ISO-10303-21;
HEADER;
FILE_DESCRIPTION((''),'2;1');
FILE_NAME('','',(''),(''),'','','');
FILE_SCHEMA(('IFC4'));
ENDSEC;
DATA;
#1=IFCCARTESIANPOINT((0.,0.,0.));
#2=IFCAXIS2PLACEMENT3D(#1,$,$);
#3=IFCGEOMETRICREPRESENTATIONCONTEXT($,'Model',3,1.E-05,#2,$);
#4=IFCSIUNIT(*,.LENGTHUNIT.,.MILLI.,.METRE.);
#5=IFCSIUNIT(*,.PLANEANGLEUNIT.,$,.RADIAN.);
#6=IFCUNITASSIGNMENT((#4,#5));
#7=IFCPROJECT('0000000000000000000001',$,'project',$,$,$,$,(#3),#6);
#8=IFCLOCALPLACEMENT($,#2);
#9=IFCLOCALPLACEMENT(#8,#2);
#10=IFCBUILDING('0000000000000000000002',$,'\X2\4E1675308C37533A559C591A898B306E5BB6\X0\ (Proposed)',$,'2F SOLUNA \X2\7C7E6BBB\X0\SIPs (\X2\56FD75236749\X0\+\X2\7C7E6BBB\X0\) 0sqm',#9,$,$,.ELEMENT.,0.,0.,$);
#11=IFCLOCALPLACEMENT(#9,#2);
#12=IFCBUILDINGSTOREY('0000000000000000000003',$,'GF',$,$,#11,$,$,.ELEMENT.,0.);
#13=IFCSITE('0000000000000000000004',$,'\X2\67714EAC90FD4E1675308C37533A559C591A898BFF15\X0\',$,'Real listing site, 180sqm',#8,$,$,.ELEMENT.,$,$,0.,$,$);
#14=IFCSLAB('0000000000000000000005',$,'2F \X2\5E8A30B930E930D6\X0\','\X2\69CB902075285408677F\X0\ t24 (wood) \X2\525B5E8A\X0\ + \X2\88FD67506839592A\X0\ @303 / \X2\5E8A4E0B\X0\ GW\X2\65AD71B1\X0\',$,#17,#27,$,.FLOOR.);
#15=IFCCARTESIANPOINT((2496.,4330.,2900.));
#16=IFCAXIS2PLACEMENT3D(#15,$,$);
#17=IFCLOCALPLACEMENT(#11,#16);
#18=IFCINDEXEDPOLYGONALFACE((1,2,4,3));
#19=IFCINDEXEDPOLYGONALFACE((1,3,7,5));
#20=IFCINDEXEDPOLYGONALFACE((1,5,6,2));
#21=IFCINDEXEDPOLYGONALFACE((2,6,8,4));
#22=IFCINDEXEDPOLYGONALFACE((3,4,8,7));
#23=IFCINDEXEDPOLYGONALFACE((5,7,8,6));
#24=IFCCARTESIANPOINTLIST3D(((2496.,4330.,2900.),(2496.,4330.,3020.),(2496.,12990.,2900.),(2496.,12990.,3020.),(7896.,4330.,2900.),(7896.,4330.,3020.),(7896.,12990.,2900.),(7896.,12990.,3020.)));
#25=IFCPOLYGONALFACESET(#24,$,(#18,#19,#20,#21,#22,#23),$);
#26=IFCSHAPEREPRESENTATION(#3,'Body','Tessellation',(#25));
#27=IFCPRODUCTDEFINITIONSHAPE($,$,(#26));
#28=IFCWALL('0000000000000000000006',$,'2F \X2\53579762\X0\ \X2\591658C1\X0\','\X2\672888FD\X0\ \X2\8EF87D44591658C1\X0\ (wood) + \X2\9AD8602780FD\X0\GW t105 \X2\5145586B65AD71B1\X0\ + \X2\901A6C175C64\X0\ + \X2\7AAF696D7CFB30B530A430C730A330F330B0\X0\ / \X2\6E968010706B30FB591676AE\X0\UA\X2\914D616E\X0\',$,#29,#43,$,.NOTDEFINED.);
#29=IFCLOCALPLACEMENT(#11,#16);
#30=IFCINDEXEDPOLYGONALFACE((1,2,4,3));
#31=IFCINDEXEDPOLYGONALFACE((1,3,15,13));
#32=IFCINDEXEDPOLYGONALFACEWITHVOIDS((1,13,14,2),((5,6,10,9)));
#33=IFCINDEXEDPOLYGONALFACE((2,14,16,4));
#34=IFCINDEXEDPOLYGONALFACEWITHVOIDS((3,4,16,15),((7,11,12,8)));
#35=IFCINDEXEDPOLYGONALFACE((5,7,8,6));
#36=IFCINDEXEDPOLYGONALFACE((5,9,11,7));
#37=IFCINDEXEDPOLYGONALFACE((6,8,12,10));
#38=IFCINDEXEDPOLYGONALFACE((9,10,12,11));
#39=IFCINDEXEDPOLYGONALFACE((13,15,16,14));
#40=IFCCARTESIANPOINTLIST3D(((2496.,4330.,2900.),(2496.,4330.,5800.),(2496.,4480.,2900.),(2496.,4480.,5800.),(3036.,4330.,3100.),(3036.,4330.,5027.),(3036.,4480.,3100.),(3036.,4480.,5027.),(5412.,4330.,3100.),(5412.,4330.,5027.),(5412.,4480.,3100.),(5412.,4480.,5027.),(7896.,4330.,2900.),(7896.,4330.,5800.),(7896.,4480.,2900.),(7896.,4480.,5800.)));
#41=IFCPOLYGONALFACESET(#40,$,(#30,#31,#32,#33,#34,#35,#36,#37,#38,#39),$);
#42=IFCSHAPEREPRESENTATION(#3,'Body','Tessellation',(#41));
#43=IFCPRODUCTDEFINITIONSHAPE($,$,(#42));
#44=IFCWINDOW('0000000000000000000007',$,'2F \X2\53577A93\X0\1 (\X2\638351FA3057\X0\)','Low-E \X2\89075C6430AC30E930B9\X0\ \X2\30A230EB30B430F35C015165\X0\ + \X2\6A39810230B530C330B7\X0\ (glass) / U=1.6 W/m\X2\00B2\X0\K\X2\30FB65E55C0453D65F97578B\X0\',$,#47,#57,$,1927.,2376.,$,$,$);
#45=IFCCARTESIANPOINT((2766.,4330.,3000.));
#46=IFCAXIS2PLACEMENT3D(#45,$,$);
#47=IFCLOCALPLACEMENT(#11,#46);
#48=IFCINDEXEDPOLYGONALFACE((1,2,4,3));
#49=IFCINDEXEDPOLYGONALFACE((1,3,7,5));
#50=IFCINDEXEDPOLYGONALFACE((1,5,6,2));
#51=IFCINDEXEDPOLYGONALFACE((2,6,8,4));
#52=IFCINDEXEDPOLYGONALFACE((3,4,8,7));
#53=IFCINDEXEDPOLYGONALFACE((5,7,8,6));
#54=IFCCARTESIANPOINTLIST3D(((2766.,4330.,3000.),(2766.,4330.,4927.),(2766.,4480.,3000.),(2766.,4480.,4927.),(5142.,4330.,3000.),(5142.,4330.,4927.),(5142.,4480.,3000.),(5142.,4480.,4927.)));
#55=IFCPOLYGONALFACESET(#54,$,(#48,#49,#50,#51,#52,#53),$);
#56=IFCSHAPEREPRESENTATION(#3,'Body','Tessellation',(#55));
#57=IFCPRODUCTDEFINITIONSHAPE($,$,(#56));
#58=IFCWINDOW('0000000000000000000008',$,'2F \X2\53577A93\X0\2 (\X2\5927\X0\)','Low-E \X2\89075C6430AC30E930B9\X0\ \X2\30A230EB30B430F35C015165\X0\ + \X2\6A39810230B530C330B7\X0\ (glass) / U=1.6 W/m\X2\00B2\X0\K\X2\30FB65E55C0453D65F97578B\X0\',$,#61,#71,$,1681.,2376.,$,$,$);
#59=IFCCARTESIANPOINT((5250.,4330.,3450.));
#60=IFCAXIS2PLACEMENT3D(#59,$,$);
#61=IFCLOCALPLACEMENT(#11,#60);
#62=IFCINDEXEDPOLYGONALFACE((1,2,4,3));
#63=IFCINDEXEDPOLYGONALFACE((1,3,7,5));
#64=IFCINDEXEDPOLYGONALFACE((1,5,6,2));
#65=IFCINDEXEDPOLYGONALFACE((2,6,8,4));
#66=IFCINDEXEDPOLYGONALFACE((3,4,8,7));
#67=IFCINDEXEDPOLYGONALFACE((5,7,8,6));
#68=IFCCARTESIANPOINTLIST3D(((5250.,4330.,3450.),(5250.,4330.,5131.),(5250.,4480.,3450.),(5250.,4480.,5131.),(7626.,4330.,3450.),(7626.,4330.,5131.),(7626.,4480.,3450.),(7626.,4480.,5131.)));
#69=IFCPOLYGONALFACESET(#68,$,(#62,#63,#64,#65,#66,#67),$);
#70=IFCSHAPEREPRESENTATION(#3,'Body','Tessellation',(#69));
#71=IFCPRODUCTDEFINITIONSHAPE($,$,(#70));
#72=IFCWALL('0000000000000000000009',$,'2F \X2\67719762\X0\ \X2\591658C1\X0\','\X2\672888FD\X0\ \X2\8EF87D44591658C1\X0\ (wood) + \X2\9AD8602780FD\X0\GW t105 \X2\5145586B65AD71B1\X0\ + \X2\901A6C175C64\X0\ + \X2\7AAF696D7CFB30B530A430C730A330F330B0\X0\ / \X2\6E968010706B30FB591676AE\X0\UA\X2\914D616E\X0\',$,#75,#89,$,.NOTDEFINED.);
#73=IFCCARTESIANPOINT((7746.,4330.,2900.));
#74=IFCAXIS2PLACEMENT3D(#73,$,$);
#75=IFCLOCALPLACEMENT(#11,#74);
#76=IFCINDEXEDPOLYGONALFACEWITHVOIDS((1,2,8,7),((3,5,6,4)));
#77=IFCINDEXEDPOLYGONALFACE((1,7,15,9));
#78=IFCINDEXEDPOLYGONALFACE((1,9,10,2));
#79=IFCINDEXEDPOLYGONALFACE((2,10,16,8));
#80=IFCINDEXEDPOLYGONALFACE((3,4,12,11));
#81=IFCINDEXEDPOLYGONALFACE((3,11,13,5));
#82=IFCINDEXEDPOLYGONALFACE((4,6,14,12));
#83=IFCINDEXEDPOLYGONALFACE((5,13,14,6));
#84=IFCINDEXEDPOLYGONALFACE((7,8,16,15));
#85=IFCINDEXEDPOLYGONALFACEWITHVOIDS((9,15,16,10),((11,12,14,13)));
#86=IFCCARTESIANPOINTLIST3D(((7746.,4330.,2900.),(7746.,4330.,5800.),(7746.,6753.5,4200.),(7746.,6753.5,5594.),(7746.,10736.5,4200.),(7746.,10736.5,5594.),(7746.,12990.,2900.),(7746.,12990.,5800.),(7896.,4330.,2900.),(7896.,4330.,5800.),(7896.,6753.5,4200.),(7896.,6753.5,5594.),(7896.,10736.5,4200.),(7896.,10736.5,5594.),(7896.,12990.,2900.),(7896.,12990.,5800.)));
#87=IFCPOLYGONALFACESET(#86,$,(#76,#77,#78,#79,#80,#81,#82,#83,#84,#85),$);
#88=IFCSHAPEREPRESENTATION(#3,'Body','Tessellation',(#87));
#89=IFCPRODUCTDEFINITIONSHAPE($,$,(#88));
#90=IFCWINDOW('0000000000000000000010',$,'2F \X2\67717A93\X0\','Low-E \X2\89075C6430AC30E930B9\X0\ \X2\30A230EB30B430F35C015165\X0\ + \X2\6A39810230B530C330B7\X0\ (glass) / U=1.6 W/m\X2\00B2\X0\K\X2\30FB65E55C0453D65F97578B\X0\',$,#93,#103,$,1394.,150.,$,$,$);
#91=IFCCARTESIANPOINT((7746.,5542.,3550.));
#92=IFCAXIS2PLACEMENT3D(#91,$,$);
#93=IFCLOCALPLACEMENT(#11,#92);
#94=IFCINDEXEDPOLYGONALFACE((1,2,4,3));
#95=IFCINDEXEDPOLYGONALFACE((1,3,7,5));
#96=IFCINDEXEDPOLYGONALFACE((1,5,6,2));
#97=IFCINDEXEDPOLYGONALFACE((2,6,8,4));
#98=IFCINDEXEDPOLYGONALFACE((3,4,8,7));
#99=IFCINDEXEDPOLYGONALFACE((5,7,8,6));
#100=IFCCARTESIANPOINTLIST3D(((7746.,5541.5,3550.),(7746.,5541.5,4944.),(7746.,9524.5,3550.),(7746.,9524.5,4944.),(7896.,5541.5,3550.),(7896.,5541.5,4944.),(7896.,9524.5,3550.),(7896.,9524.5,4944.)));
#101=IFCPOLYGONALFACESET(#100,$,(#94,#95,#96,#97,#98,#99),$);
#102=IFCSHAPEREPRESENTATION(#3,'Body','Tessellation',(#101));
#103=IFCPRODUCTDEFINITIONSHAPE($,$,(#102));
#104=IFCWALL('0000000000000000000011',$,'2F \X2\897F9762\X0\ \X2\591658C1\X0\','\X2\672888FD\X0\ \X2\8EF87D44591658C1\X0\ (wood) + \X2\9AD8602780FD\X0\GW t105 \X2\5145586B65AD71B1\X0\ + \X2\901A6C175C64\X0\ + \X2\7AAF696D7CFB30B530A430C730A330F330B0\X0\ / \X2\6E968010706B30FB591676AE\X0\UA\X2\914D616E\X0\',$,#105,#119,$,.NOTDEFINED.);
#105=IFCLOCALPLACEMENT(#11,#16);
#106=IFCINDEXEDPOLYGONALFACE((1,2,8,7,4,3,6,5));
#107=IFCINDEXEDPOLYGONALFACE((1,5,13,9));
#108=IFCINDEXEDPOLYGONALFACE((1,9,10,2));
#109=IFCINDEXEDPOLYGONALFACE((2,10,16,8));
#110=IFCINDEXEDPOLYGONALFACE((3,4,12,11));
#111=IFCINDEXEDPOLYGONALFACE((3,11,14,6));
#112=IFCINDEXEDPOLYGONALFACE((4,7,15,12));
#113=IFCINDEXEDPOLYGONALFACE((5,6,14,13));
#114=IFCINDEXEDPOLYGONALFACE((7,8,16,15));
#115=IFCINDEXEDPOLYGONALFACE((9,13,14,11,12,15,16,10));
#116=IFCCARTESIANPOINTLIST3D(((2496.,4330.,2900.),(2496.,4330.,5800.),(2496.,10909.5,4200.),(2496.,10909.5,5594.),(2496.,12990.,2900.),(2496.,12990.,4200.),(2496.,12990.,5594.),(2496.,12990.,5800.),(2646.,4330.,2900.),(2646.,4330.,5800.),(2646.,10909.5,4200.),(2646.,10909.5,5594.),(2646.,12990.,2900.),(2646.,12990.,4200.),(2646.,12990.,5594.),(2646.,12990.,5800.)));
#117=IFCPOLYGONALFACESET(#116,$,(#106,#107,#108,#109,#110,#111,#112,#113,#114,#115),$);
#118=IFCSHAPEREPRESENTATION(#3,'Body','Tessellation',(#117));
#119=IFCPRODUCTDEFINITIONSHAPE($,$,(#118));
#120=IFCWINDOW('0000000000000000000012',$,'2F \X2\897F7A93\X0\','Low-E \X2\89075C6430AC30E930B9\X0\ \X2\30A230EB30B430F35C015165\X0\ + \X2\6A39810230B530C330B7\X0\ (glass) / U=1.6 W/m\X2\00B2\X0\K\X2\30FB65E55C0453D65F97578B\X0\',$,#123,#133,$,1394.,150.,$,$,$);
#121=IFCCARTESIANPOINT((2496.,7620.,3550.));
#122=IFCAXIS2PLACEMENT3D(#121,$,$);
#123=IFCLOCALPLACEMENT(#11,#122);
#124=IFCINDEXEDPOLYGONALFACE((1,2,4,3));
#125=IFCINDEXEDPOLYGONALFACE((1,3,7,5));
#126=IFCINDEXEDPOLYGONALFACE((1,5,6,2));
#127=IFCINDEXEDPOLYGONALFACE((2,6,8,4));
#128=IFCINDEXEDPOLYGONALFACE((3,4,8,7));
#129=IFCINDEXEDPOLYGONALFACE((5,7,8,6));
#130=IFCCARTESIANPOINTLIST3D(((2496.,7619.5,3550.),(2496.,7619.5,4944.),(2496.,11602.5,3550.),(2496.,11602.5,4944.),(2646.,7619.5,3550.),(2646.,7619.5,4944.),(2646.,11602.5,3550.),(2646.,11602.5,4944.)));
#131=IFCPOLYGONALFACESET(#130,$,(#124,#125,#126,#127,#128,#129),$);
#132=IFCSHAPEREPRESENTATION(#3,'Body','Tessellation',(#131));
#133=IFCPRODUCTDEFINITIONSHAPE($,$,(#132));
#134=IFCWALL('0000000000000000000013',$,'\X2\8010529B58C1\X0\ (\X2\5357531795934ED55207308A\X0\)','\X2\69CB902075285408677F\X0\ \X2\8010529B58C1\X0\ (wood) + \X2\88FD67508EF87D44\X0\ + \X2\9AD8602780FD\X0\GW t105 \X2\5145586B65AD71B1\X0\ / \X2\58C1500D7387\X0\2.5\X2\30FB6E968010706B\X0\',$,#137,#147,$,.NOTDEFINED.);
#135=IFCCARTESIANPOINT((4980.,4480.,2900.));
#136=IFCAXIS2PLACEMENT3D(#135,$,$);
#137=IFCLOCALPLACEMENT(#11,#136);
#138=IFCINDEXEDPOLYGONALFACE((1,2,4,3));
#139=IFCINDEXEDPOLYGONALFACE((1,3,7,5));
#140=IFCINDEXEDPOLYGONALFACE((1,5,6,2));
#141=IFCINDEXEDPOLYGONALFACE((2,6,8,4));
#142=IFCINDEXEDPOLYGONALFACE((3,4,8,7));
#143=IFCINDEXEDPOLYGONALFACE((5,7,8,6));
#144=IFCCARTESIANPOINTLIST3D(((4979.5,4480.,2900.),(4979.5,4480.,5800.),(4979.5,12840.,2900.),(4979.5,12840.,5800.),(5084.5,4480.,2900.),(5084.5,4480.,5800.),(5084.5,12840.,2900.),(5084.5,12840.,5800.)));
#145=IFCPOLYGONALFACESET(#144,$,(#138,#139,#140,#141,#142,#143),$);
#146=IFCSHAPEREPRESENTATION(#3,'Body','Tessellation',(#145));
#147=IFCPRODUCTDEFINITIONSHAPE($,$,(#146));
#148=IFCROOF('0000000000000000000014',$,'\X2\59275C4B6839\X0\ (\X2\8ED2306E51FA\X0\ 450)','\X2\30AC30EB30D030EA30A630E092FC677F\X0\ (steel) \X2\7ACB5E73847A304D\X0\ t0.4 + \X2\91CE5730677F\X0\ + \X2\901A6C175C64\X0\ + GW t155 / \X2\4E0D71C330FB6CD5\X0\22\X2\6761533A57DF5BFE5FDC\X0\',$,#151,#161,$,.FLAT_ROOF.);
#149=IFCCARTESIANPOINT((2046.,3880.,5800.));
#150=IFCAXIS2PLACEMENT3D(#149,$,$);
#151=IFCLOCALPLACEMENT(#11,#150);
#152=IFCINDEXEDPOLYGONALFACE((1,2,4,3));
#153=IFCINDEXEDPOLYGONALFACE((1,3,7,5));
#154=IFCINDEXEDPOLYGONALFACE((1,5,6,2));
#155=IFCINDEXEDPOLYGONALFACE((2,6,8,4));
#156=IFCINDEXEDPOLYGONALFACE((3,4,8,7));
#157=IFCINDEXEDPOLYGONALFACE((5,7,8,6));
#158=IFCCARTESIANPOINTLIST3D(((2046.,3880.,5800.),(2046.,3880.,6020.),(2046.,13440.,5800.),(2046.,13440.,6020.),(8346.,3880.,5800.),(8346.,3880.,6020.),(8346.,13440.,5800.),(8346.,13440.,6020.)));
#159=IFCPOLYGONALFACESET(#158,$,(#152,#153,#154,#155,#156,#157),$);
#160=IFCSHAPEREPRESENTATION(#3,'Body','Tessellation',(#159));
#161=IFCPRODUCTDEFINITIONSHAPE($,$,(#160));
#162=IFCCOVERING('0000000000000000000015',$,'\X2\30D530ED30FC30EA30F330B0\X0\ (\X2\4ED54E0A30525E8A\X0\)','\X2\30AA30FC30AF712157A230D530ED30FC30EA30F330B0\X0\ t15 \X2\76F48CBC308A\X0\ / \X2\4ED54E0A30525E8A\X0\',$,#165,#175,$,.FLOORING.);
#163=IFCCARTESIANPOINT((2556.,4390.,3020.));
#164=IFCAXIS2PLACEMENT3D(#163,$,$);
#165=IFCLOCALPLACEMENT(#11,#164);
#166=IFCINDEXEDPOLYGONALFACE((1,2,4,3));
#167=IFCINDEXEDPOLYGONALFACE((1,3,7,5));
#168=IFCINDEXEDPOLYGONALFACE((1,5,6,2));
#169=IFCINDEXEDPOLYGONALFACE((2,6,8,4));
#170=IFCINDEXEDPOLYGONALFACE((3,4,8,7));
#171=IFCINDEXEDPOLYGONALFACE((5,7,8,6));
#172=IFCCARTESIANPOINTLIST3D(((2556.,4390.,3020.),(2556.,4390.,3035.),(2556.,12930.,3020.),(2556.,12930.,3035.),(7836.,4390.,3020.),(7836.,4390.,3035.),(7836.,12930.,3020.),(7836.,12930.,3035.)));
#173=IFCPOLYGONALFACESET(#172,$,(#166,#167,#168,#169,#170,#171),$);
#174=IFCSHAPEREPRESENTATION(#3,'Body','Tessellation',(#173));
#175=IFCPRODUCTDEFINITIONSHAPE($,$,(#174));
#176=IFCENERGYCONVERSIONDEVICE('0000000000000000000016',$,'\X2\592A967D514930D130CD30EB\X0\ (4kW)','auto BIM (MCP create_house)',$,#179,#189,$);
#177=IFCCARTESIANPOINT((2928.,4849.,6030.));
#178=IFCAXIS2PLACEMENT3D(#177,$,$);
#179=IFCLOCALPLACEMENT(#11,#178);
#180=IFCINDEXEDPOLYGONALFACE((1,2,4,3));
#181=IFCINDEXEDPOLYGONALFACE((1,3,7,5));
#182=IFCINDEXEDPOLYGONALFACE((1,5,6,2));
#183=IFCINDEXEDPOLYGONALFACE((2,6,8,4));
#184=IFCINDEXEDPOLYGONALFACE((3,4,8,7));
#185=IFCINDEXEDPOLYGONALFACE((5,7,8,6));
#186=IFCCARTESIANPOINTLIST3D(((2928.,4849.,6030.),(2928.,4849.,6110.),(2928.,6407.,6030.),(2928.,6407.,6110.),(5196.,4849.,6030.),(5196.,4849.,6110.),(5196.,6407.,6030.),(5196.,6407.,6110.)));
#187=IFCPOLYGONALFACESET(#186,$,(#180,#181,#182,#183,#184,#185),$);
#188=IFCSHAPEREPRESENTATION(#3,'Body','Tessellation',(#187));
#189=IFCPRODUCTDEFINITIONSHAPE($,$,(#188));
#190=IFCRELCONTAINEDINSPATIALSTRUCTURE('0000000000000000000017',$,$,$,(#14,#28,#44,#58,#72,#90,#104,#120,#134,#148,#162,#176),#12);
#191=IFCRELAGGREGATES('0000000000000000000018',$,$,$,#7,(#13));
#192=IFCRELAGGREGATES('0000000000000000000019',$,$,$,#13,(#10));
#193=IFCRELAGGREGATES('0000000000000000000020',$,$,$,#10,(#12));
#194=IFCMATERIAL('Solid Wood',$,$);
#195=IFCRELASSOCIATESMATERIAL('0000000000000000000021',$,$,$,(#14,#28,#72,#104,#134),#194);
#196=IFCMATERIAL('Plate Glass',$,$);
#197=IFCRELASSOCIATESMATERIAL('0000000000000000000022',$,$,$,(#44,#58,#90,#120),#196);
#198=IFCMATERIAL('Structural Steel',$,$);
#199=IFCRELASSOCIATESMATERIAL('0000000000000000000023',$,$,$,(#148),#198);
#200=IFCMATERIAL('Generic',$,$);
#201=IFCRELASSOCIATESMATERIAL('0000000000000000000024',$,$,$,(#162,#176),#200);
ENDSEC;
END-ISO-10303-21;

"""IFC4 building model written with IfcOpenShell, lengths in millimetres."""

from ifc_helpers import new_model, si_unit, frame, frame_2d, origin, place, context, project, spatial, rectangle, extrude, material, element, fill, save


model = new_model("IFC4")

# Units and contexts
model_context = context("Model", 3, precision=1e-05, world=origin())
ifc_project = project(units=[si_unit("LENGTHUNIT", "METRE", prefix="MILLI"), si_unit("PLANEANGLEUNIT", "RADIAN")], contexts=[model_context])

# Site, building, storey
site_placement = place(None, origin())
site = spatial("IfcSite", under=ifc_project, at=site_placement, Name="東京都世田谷区喜多見５", ObjectType="Real listing site, 180sqm", CompositionType="ELEMENT", RefElevation=0.0)
building_placement = place(site_placement, origin())
building = spatial("IfcBuilding", under=site, at=building_placement, Name="世田谷区喜多見の家 (Proposed)", ObjectType="2F SOLUNA 籾殻SIPs (国産杉+籾殻) 0sqm", CompositionType="ELEMENT", ElevationOfRefHeight=0.0, ElevationOfTerrain=0.0)
storey_placement = place(building_placement, origin())
storey = spatial("IfcBuildingStorey", under=building, at=storey_placement, Name="GF", CompositionType="ELEMENT", Elevation=0.0)

# Slab
ifc_material_1 = material(Name="Solid Wood")
slab_placement = place(storey_placement, frame((2496.0, 4330.0, 2900.0)))
element("IfcSlab", 1, at=slab_placement, inside=storey, material=ifc_material_1, Name="2F 床スラブ", Description="構造用合板 t24 (wood) 剛床 + 製材根太 @303 / 床下 GW断熱", PredefinedType="FLOOR", context=model_context, shape_type="SweptSolid", body=[
    extrude(rectangle(XDim=5400.0, YDim=8660.0, at=frame_2d((2700.0, 4330.0))), frame((2496.0, 4330.0, 2900.0)), (0.0, 0.0, 1.0), 120.0),
])

# Wall, openings, windows
wall_1_placement = place(storey_placement, frame((2496.0, 4330.0, 2900.0)))
wall_1 = element("IfcWall", 2, at=wall_1_placement, inside=storey, material=ifc_material_1, Name="2F 南面 外壁", Description="木製 軸組外壁 (wood) + 高性能GW t105 充填断熱 + 通気層 + 窯業系サイディング / 準耐火・外皮UA配慮", PredefinedType="NOTDEFINED", context=model_context, shape_type="SweptSolid", body=[
    extrude(rectangle(XDim=5400.0, YDim=150.0, at=frame_2d((2700.0, 75.0))), frame((2496.0, 4330.0, 2900.0)), (0.0, 0.0, 1.0), 2900.0),
])
opening_1_placement = place(storey_placement, frame((2766.0, 4330.0, 3000.0)))
opening_1 = element("IfcOpeningElement", 3, at=opening_1_placement, cuts=wall_1, PredefinedType="NOTDEFINED", context=model_context, shape_type="SweptSolid", body=[
    extrude(rectangle(XDim=2376.0, YDim=150.0, at=frame_2d((1188.0, 75.0))), frame((2766.0, 4330.0, 3000.0)), (0.0, 0.0, 1.0), 1927.0),
])
opening_2_placement = place(storey_placement, frame((5250.0, 4330.0, 3450.0)))
opening_2 = element("IfcOpeningElement", 4, at=opening_2_placement, cuts=wall_1, PredefinedType="NOTDEFINED", context=model_context, shape_type="SweptSolid", body=[
    extrude(rectangle(XDim=2376.0, YDim=150.0, at=frame_2d((1188.0, 75.0))), frame((5250.0, 4330.0, 3450.0)), (0.0, 0.0, 1.0), 1681.0),
])
ifc_material_2 = material(Name="Plate Glass")
window_1_placement = place(storey_placement, frame((2766.0, 4330.0, 3000.0)))
window_1 = element("IfcWindow", 5, at=window_1_placement, inside=storey, material=ifc_material_2, Name="2F 南窓1 (掃出し)", Description="Low-E 複層ガラス アルゴン封入 + 樹脂サッシ (glass) / U=1.6 W/m²K・日射取得型", OverallHeight=1927.0, OverallWidth=2376.0, context=model_context, shape_type="SweptSolid", body=[
    extrude(rectangle(XDim=2376.0, YDim=150.0, at=frame_2d((1188.0, 75.0))), frame((2766.0, 4330.0, 3000.0)), (0.0, 0.0, 1.0), 1927.0),
])
fill(opening_1, window_1)
window_2_placement = place(storey_placement, frame((5250.0, 4330.0, 3450.0)))
window_2 = element("IfcWindow", 6, at=window_2_placement, inside=storey, material=ifc_material_2, Name="2F 南窓2 (大)", Description="Low-E 複層ガラス アルゴン封入 + 樹脂サッシ (glass) / U=1.6 W/m²K・日射取得型", OverallHeight=1681.0, OverallWidth=2376.0, context=model_context, shape_type="SweptSolid", body=[
    extrude(rectangle(XDim=2376.0, YDim=150.0, at=frame_2d((1188.0, 75.0))), frame((5250.0, 4330.0, 3450.0)), (0.0, 0.0, 1.0), 1681.0),
])
fill(opening_2, window_2)

# Walls, openings, windows
wall_2_placement = place(storey_placement, frame((7746.0, 4330.0, 2900.0)))
wall_2 = element("IfcWall", 7, at=wall_2_placement, inside=storey, material=ifc_material_1, Name="2F 東面 外壁", Description="木製 軸組外壁 (wood) + 高性能GW t105 充填断熱 + 通気層 + 窯業系サイディング / 準耐火・外皮UA配慮", PredefinedType="NOTDEFINED", context=model_context, shape_type="SweptSolid", body=[
    extrude(rectangle(XDim=150.0, YDim=8660.0, at=frame_2d((75.0, 4330.0))), frame((7746.0, 4330.0, 2900.0)), (0.0, 0.0, 1.0), 2900.0),
])
opening_3_placement = place(storey_placement, frame((7746.0, 5542.0, 3550.0)))
opening_3 = element("IfcOpeningElement", 8, at=opening_3_placement, cuts=wall_2, PredefinedType="NOTDEFINED", context=model_context, shape_type="SweptSolid", body=[
    extrude(rectangle(XDim=150.0, YDim=3983.0, at=frame_2d((75.0, 1991.0))), frame((7746.0, 5542.0, 3550.0)), (0.0, 0.0, 1.0), 1394.0),
])
window_3_placement = place(storey_placement, frame((7746.0, 5542.0, 3550.0)))
window_3 = element("IfcWindow", 9, at=window_3_placement, inside=storey, material=ifc_material_2, Name="2F 東窓", Description="Low-E 複層ガラス アルゴン封入 + 樹脂サッシ (glass) / U=1.6 W/m²K・日射取得型", OverallHeight=1394.0, OverallWidth=150.0, context=model_context, shape_type="SweptSolid", body=[
    extrude(rectangle(XDim=150.0, YDim=3983.0, at=frame_2d((75.0, 1991.0))), frame((7746.0, 5542.0, 3550.0)), (0.0, 0.0, 1.0), 1394.0),
])
fill(opening_3, window_3)
wall_3_placement = place(storey_placement, frame((2496.0, 4330.0, 2900.0)))
wall_3 = element("IfcWall", 10, at=wall_3_placement, inside=storey, material=ifc_material_1, Name="2F 西面 外壁", Description="木製 軸組外壁 (wood) + 高性能GW t105 充填断熱 + 通気層 + 窯業系サイディング / 準耐火・外皮UA配慮", PredefinedType="NOTDEFINED", context=model_context, shape_type="SweptSolid", body=[
    extrude(rectangle(XDim=150.0, YDim=8660.0, at=frame_2d((75.0, 4330.0))), frame((2496.0, 4330.0, 2900.0)), (0.0, 0.0, 1.0), 2900.0),
])
opening_4_placement = place(storey_placement, frame((2496.0, 7620.0, 3550.0)))
opening_4 = element("IfcOpeningElement", 11, at=opening_4_placement, cuts=wall_3, PredefinedType="NOTDEFINED", context=model_context, shape_type="SweptSolid", body=[
    extrude(rectangle(XDim=150.0, YDim=3983.0, at=frame_2d((75.0, 1991.0))), frame((2496.0, 7620.0, 3550.0)), (0.0, 0.0, 1.0), 1394.0),
])
window_4_placement = place(storey_placement, frame((2496.0, 7620.0, 3550.0)))
window_4 = element("IfcWindow", 12, at=window_4_placement, inside=storey, material=ifc_material_2, Name="2F 西窓", Description="Low-E 複層ガラス アルゴン封入 + 樹脂サッシ (glass) / U=1.6 W/m²K・日射取得型", OverallHeight=1394.0, OverallWidth=150.0, context=model_context, shape_type="SweptSolid", body=[
    extrude(rectangle(XDim=150.0, YDim=3983.0, at=frame_2d((75.0, 1991.0))), frame((2496.0, 7620.0, 3550.0)), (0.0, 0.0, 1.0), 1394.0),
])
fill(opening_4, window_4)

# Wall
wall_4_placement = place(storey_placement, frame((4980.0, 4480.0, 2900.0)))
element("IfcWall", 13, at=wall_4_placement, inside=storey, material=ifc_material_1, Name="耐力壁 (南北間仕切り)", Description="構造用合板 耐力壁 (wood) + 製材軸組 + 高性能GW t105 充填断熱 / 壁倍率2.5・準耐火", PredefinedType="NOTDEFINED", context=model_context, shape_type="SweptSolid", body=[
    extrude(rectangle(XDim=105.0, YDim=8360.0, at=frame_2d((52.0, 4180.0))), frame((4980.0, 4480.0, 2900.0)), (0.0, 0.0, 1.0), 2900.0),
])

# Roof
ifc_material_3 = material(Name="Structural Steel")
roof_placement = place(storey_placement, frame((2046.0, 3880.0, 5800.0)))
element("IfcRoof", 14, at=roof_placement, inside=storey, material=ifc_material_3, Name="大屋根 (軒の出 450)", Description="ガルバリウム鋼板 (steel) 立平葺き t0.4 + 野地板 + 通気層 + GW t155 / 不燃・法22条区域対応", PredefinedType="FLAT_ROOF", context=model_context, shape_type="SweptSolid", body=[
    extrude(rectangle(XDim=6300.0, YDim=9560.0, at=frame_2d((3150.0, 4780.0))), frame((2046.0, 3880.0, 5800.0)), (0.0, 0.0, 1.0), 220.0),
])

# Covering
ifc_material_4 = material(Name="Generic")
covering_placement = place(storey_placement, frame((2556.0, 4390.0, 3020.0)))
element("IfcCovering", 15, at=covering_placement, inside=storey, material=ifc_material_4, Name="フローリング (仕上げ床)", Description="オーク無垢フローリング t15 直貼り / 仕上げ床", PredefinedType="FLOORING", context=model_context, shape_type="SweptSolid", body=[
    extrude(rectangle(XDim=5280.0, YDim=8540.0, at=frame_2d((2640.0, 4270.0))), frame((2556.0, 4390.0, 3020.0)), (0.0, 0.0, 1.0), 15.0),
])

# Energy conversion device
energy_conversion_device_placement = place(storey_placement, frame((2928.0, 4849.0, 6030.0)))
element("IfcEnergyConversionDevice", 16, at=energy_conversion_device_placement, inside=storey, material=ifc_material_4, Name="太陽光パネル (4kW)", Description="auto BIM (MCP create_house)", context=model_context, shape_type="SweptSolid", body=[
    extrude(rectangle(XDim=2268.0, YDim=1558.0, at=frame_2d((1134.0, 779.0))), frame((2928.0, 4849.0, 6030.0)), (0.0, 0.0, 1.0), 80.0),
])

save(model, "model.ifc")
